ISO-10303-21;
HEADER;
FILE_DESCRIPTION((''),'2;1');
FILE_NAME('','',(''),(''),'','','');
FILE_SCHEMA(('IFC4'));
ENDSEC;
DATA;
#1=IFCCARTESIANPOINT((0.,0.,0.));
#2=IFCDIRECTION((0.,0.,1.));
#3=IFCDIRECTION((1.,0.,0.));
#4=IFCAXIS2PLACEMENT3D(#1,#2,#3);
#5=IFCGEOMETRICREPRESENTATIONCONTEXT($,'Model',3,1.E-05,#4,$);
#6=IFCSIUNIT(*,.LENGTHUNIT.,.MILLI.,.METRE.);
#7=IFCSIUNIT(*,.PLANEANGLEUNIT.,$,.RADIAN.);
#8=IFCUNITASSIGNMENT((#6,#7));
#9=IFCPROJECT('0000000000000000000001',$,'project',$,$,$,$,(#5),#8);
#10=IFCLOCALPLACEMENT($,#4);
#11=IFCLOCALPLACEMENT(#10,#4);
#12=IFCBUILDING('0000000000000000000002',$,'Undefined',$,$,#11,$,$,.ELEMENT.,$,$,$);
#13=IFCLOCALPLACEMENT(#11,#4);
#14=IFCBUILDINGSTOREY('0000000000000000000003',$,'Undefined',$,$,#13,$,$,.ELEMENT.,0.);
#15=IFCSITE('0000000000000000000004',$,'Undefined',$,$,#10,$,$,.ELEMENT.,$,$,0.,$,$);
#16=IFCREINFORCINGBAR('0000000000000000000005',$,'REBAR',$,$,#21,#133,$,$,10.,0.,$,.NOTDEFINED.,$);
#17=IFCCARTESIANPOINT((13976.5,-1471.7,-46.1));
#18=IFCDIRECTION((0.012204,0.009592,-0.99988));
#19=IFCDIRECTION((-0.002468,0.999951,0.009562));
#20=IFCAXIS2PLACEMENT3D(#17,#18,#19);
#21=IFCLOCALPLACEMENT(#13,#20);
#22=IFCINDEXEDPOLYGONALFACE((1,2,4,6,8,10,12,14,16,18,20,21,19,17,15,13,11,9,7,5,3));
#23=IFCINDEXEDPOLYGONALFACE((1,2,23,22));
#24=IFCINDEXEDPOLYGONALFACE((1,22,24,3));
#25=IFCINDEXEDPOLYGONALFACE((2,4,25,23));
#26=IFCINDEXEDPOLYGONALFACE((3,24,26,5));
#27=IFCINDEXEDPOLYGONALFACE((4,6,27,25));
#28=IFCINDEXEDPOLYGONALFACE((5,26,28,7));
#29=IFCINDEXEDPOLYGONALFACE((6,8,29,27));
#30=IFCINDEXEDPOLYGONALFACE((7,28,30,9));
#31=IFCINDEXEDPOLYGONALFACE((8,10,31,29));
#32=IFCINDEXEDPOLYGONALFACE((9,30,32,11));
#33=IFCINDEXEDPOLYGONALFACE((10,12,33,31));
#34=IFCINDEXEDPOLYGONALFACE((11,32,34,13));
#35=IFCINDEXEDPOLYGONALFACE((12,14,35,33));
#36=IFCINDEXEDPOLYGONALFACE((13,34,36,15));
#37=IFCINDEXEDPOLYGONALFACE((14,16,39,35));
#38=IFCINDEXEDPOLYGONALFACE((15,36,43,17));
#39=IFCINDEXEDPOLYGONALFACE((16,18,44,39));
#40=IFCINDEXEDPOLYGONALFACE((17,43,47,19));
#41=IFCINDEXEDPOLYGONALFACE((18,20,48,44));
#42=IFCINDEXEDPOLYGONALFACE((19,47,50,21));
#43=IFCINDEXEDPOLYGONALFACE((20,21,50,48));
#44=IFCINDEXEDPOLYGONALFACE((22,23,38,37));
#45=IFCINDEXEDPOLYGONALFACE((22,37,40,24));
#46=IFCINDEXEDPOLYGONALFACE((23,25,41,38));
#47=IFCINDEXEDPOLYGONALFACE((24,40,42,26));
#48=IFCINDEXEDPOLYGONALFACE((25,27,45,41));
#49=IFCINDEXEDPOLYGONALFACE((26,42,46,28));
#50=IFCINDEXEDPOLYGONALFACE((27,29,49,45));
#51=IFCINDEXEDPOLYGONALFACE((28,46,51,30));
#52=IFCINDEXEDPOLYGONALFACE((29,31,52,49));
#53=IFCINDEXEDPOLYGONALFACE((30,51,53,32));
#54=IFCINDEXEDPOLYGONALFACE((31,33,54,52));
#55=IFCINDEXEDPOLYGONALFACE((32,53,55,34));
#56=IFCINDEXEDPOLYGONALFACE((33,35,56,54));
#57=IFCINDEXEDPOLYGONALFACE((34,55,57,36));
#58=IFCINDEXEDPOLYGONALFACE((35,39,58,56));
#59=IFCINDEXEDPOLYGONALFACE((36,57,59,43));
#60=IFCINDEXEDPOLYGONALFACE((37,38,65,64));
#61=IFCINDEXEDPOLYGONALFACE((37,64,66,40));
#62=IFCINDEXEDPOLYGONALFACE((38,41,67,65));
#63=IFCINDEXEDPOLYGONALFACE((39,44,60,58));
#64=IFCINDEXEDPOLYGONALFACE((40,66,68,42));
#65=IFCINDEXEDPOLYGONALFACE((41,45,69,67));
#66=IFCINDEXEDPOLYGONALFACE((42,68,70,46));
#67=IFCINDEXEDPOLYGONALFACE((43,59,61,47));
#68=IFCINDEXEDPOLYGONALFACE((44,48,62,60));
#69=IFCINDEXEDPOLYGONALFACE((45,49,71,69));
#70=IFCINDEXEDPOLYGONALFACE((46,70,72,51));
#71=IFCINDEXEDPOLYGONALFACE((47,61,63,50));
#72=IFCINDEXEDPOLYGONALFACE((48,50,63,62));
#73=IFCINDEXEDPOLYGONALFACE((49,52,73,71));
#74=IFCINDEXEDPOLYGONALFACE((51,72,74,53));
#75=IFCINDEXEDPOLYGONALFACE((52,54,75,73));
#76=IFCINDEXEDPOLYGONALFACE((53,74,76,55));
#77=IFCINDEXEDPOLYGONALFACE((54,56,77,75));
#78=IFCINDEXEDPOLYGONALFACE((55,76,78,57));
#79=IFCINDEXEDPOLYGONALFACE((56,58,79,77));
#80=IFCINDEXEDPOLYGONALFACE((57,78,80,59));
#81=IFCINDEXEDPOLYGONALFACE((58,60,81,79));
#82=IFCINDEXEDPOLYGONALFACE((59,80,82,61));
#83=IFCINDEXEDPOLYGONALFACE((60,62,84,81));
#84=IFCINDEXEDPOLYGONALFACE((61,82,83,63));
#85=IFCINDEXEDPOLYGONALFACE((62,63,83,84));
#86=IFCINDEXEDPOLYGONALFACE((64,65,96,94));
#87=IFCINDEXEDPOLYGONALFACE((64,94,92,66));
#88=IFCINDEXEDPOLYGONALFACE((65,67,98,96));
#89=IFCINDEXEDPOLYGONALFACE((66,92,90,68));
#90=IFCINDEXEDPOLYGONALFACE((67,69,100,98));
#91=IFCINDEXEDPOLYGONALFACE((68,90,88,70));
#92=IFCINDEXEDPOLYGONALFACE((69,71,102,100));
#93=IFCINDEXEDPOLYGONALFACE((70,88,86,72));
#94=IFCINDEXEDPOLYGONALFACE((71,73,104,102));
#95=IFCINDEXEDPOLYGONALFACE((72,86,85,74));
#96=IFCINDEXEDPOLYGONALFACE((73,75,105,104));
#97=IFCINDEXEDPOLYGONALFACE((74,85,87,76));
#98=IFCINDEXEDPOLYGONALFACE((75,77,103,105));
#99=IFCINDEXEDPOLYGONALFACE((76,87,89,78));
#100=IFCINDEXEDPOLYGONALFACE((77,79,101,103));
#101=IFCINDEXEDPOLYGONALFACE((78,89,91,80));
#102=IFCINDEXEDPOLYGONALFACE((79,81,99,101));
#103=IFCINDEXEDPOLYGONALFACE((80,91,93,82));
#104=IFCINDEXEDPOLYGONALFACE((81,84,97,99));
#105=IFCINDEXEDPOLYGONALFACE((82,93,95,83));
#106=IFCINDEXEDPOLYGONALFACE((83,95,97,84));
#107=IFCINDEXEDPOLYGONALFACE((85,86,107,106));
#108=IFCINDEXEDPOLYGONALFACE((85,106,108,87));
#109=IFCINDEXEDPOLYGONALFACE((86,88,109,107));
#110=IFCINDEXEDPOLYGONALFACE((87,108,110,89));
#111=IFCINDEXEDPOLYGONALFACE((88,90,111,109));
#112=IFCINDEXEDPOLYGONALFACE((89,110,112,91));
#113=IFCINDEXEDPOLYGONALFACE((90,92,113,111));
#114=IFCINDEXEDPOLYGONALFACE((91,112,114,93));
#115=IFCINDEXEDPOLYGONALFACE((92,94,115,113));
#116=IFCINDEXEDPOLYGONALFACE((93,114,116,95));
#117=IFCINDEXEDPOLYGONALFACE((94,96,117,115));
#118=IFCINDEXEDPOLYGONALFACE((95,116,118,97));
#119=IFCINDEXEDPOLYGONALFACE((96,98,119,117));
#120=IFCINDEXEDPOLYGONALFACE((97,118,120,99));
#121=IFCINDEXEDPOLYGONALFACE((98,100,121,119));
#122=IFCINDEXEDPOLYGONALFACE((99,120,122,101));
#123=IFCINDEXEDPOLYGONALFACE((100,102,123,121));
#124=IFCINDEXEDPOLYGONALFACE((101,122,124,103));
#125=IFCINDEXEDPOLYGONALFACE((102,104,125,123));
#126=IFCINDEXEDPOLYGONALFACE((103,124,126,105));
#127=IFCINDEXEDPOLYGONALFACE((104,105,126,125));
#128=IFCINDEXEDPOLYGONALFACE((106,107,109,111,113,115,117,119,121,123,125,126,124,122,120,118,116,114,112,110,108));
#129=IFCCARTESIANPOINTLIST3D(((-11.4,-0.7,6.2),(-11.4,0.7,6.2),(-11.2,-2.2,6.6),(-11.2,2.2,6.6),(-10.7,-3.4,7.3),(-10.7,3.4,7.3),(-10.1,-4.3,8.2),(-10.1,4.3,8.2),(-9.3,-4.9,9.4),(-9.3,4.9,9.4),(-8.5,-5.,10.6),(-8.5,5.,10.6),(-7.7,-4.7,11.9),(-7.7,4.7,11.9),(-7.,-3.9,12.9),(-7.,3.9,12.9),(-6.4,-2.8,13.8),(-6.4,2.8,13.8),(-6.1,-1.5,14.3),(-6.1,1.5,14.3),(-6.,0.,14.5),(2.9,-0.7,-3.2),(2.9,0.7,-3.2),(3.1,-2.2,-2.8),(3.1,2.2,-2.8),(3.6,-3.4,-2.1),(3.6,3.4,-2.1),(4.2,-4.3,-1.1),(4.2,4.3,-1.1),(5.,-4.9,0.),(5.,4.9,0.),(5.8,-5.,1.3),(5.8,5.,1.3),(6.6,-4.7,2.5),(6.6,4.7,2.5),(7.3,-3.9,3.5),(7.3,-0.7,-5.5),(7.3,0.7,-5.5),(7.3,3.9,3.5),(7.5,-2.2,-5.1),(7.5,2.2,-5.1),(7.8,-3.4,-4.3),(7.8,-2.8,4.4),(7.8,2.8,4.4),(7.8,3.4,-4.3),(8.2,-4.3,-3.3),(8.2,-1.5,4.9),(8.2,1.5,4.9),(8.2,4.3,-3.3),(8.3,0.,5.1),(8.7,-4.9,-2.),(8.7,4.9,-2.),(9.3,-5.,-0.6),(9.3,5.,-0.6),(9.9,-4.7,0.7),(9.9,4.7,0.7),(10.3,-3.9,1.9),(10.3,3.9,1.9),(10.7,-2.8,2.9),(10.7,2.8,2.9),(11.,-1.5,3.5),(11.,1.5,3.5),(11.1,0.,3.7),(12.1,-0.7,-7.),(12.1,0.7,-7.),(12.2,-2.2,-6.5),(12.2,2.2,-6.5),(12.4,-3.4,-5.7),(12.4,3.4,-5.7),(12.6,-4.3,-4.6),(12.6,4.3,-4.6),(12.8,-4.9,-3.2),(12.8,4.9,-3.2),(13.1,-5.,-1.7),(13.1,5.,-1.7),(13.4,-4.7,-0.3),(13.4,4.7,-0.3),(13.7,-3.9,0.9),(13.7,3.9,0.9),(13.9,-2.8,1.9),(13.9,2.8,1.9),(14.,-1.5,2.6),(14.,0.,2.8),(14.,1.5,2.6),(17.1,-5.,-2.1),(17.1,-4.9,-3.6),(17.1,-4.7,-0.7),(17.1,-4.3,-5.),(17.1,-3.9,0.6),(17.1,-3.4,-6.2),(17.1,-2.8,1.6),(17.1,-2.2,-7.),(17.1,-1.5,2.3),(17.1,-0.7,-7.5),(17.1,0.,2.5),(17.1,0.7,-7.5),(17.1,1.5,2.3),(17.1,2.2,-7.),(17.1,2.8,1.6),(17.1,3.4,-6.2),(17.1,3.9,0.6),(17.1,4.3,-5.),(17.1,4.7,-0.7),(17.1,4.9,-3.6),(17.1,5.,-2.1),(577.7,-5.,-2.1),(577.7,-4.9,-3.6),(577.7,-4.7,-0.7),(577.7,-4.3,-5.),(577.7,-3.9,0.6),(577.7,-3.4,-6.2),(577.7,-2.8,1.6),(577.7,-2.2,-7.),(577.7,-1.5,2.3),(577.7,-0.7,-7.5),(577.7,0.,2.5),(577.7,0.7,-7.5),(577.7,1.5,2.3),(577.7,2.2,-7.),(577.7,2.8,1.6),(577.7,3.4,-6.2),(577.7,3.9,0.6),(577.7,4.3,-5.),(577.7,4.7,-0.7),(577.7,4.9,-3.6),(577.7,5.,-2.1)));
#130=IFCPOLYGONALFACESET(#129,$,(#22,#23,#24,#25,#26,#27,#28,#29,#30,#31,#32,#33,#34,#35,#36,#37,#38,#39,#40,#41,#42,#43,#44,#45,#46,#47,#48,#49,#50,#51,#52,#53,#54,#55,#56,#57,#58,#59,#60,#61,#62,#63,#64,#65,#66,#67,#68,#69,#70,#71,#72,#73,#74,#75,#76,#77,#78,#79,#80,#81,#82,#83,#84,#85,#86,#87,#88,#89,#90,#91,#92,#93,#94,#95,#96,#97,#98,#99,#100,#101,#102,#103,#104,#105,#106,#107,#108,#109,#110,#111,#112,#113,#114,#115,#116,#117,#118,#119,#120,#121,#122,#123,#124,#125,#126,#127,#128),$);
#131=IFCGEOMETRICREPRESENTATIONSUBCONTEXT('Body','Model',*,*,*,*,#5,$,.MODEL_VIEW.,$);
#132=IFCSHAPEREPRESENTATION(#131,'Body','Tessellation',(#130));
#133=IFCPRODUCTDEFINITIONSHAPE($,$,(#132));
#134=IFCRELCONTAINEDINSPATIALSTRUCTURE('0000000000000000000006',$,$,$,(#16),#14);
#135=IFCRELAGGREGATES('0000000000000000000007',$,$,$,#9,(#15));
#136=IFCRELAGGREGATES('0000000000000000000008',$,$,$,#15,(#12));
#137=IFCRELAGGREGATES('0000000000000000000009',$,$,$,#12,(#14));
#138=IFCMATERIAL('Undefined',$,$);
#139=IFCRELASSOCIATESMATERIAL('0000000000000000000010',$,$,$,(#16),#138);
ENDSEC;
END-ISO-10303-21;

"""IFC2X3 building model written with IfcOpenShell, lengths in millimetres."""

from ifc_helpers import new_model, entity, si_unit, frame, origin_with_axes, place, context, subcontext, project, spatial, source, transform, mapped, material, element, save


model = new_model("IFC2X3")

# Units and contexts
model_context = context("Model", 3, precision=1e-05, world=origin_with_axes())
body_context = subcontext(model_context, "Body", "Model", "MODEL_VIEW")
ifc_project = project(units=[si_unit("LENGTHUNIT", "METRE", prefix="MILLI"), si_unit("PLANEANGLEUNIT", "RADIAN")], contexts=[model_context])

# Site, building, storey
site_placement = place(None, origin_with_axes())
site = spatial("IfcSite", under=ifc_project, at=site_placement, Name="Undefined", CompositionType="ELEMENT", RefElevation=0.0)
building_placement = place(site_placement, origin_with_axes())
building = spatial("IfcBuilding", under=site, at=building_placement, Name="Undefined", CompositionType="ELEMENT")
storey_placement = place(building_placement, origin_with_axes())
storey = spatial("IfcBuildingStorey", under=building, at=storey_placement, Name="Undefined", CompositionType="ELEMENT", Elevation=0.0)

# Reinforcing bar
ifc_material_1 = material(Name="Undefined")
shared_shape_1 = source(origin_with_axes(), body_context, "Body", "AdvancedSweptSolid", [
    entity("IfcSweptDiskSolid", entity("IfcCompositeCurve", [entity("IfcCompositeCurveSegment", "CONTINUOUS", True, entity("IfcTrimmedCurve", entity("IfcLine", entity("IfcCartesianPoint", [0.0, 0.0, 0.0]), entity("IfcVector", entity("IfcDirection", [0.835483, 0.0, -0.549516]), 1.0)), [entity("IfcParameterValue", 0.0)], [entity("IfcParameterValue", 17.082101)], True, "PARAMETER")), entity("IfcCompositeCurveSegment", "CONTINUOUS", True, entity("IfcTrimmedCurve", entity("IfcCircle", entity("IfcAxis2Placement3D", entity("IfcCartesianPoint", [25.8, 0.0, 8.2]), entity("IfcDirection", [0.0, -1.0, 0.0]), entity("IfcDirection", [-0.549516, 0.0, -0.835483])), 21.0), [entity("IfcParameterValue", 0.0)], [entity("IfcParameterValue", 0.581785)], True, "PARAMETER")), entity("IfcCompositeCurveSegment", "DISCONTINUOUS", True, entity("IfcTrimmedCurve", entity("IfcLine", entity("IfcCartesianPoint", [25.8, 0.0, -12.8]), entity("IfcVector", entity("IfcDirection", [1.0, 0.0, 0.0]), 1.0)), [entity("IfcParameterValue", 0.0)], [entity("IfcParameterValue", 560.593055)], True, "PARAMETER"))], False), 5.0, None, 0.0, 578.3),
])
reinforcing_bar_1_placement = place(storey_placement, frame((13976.5, -1471.7, -46.1), z_axis=(0.012204, 0.009592, -0.99988), x_axis=(-0.002468, 0.999951, 0.009562)))
element("IfcReinforcingBar", 1, at=reinforcing_bar_1_placement, inside=storey, material=ifc_material_1, Name="REBAR", BarRole="NOTDEFINED", CrossSectionArea=0.0, NominalDiameter=10.0, context=body_context, shape_type="MappedRepresentation", body=[
    mapped(shared_shape_1, transform((-8.7, 0.0, 10.3))),
])

save(model, "model.ifc")
